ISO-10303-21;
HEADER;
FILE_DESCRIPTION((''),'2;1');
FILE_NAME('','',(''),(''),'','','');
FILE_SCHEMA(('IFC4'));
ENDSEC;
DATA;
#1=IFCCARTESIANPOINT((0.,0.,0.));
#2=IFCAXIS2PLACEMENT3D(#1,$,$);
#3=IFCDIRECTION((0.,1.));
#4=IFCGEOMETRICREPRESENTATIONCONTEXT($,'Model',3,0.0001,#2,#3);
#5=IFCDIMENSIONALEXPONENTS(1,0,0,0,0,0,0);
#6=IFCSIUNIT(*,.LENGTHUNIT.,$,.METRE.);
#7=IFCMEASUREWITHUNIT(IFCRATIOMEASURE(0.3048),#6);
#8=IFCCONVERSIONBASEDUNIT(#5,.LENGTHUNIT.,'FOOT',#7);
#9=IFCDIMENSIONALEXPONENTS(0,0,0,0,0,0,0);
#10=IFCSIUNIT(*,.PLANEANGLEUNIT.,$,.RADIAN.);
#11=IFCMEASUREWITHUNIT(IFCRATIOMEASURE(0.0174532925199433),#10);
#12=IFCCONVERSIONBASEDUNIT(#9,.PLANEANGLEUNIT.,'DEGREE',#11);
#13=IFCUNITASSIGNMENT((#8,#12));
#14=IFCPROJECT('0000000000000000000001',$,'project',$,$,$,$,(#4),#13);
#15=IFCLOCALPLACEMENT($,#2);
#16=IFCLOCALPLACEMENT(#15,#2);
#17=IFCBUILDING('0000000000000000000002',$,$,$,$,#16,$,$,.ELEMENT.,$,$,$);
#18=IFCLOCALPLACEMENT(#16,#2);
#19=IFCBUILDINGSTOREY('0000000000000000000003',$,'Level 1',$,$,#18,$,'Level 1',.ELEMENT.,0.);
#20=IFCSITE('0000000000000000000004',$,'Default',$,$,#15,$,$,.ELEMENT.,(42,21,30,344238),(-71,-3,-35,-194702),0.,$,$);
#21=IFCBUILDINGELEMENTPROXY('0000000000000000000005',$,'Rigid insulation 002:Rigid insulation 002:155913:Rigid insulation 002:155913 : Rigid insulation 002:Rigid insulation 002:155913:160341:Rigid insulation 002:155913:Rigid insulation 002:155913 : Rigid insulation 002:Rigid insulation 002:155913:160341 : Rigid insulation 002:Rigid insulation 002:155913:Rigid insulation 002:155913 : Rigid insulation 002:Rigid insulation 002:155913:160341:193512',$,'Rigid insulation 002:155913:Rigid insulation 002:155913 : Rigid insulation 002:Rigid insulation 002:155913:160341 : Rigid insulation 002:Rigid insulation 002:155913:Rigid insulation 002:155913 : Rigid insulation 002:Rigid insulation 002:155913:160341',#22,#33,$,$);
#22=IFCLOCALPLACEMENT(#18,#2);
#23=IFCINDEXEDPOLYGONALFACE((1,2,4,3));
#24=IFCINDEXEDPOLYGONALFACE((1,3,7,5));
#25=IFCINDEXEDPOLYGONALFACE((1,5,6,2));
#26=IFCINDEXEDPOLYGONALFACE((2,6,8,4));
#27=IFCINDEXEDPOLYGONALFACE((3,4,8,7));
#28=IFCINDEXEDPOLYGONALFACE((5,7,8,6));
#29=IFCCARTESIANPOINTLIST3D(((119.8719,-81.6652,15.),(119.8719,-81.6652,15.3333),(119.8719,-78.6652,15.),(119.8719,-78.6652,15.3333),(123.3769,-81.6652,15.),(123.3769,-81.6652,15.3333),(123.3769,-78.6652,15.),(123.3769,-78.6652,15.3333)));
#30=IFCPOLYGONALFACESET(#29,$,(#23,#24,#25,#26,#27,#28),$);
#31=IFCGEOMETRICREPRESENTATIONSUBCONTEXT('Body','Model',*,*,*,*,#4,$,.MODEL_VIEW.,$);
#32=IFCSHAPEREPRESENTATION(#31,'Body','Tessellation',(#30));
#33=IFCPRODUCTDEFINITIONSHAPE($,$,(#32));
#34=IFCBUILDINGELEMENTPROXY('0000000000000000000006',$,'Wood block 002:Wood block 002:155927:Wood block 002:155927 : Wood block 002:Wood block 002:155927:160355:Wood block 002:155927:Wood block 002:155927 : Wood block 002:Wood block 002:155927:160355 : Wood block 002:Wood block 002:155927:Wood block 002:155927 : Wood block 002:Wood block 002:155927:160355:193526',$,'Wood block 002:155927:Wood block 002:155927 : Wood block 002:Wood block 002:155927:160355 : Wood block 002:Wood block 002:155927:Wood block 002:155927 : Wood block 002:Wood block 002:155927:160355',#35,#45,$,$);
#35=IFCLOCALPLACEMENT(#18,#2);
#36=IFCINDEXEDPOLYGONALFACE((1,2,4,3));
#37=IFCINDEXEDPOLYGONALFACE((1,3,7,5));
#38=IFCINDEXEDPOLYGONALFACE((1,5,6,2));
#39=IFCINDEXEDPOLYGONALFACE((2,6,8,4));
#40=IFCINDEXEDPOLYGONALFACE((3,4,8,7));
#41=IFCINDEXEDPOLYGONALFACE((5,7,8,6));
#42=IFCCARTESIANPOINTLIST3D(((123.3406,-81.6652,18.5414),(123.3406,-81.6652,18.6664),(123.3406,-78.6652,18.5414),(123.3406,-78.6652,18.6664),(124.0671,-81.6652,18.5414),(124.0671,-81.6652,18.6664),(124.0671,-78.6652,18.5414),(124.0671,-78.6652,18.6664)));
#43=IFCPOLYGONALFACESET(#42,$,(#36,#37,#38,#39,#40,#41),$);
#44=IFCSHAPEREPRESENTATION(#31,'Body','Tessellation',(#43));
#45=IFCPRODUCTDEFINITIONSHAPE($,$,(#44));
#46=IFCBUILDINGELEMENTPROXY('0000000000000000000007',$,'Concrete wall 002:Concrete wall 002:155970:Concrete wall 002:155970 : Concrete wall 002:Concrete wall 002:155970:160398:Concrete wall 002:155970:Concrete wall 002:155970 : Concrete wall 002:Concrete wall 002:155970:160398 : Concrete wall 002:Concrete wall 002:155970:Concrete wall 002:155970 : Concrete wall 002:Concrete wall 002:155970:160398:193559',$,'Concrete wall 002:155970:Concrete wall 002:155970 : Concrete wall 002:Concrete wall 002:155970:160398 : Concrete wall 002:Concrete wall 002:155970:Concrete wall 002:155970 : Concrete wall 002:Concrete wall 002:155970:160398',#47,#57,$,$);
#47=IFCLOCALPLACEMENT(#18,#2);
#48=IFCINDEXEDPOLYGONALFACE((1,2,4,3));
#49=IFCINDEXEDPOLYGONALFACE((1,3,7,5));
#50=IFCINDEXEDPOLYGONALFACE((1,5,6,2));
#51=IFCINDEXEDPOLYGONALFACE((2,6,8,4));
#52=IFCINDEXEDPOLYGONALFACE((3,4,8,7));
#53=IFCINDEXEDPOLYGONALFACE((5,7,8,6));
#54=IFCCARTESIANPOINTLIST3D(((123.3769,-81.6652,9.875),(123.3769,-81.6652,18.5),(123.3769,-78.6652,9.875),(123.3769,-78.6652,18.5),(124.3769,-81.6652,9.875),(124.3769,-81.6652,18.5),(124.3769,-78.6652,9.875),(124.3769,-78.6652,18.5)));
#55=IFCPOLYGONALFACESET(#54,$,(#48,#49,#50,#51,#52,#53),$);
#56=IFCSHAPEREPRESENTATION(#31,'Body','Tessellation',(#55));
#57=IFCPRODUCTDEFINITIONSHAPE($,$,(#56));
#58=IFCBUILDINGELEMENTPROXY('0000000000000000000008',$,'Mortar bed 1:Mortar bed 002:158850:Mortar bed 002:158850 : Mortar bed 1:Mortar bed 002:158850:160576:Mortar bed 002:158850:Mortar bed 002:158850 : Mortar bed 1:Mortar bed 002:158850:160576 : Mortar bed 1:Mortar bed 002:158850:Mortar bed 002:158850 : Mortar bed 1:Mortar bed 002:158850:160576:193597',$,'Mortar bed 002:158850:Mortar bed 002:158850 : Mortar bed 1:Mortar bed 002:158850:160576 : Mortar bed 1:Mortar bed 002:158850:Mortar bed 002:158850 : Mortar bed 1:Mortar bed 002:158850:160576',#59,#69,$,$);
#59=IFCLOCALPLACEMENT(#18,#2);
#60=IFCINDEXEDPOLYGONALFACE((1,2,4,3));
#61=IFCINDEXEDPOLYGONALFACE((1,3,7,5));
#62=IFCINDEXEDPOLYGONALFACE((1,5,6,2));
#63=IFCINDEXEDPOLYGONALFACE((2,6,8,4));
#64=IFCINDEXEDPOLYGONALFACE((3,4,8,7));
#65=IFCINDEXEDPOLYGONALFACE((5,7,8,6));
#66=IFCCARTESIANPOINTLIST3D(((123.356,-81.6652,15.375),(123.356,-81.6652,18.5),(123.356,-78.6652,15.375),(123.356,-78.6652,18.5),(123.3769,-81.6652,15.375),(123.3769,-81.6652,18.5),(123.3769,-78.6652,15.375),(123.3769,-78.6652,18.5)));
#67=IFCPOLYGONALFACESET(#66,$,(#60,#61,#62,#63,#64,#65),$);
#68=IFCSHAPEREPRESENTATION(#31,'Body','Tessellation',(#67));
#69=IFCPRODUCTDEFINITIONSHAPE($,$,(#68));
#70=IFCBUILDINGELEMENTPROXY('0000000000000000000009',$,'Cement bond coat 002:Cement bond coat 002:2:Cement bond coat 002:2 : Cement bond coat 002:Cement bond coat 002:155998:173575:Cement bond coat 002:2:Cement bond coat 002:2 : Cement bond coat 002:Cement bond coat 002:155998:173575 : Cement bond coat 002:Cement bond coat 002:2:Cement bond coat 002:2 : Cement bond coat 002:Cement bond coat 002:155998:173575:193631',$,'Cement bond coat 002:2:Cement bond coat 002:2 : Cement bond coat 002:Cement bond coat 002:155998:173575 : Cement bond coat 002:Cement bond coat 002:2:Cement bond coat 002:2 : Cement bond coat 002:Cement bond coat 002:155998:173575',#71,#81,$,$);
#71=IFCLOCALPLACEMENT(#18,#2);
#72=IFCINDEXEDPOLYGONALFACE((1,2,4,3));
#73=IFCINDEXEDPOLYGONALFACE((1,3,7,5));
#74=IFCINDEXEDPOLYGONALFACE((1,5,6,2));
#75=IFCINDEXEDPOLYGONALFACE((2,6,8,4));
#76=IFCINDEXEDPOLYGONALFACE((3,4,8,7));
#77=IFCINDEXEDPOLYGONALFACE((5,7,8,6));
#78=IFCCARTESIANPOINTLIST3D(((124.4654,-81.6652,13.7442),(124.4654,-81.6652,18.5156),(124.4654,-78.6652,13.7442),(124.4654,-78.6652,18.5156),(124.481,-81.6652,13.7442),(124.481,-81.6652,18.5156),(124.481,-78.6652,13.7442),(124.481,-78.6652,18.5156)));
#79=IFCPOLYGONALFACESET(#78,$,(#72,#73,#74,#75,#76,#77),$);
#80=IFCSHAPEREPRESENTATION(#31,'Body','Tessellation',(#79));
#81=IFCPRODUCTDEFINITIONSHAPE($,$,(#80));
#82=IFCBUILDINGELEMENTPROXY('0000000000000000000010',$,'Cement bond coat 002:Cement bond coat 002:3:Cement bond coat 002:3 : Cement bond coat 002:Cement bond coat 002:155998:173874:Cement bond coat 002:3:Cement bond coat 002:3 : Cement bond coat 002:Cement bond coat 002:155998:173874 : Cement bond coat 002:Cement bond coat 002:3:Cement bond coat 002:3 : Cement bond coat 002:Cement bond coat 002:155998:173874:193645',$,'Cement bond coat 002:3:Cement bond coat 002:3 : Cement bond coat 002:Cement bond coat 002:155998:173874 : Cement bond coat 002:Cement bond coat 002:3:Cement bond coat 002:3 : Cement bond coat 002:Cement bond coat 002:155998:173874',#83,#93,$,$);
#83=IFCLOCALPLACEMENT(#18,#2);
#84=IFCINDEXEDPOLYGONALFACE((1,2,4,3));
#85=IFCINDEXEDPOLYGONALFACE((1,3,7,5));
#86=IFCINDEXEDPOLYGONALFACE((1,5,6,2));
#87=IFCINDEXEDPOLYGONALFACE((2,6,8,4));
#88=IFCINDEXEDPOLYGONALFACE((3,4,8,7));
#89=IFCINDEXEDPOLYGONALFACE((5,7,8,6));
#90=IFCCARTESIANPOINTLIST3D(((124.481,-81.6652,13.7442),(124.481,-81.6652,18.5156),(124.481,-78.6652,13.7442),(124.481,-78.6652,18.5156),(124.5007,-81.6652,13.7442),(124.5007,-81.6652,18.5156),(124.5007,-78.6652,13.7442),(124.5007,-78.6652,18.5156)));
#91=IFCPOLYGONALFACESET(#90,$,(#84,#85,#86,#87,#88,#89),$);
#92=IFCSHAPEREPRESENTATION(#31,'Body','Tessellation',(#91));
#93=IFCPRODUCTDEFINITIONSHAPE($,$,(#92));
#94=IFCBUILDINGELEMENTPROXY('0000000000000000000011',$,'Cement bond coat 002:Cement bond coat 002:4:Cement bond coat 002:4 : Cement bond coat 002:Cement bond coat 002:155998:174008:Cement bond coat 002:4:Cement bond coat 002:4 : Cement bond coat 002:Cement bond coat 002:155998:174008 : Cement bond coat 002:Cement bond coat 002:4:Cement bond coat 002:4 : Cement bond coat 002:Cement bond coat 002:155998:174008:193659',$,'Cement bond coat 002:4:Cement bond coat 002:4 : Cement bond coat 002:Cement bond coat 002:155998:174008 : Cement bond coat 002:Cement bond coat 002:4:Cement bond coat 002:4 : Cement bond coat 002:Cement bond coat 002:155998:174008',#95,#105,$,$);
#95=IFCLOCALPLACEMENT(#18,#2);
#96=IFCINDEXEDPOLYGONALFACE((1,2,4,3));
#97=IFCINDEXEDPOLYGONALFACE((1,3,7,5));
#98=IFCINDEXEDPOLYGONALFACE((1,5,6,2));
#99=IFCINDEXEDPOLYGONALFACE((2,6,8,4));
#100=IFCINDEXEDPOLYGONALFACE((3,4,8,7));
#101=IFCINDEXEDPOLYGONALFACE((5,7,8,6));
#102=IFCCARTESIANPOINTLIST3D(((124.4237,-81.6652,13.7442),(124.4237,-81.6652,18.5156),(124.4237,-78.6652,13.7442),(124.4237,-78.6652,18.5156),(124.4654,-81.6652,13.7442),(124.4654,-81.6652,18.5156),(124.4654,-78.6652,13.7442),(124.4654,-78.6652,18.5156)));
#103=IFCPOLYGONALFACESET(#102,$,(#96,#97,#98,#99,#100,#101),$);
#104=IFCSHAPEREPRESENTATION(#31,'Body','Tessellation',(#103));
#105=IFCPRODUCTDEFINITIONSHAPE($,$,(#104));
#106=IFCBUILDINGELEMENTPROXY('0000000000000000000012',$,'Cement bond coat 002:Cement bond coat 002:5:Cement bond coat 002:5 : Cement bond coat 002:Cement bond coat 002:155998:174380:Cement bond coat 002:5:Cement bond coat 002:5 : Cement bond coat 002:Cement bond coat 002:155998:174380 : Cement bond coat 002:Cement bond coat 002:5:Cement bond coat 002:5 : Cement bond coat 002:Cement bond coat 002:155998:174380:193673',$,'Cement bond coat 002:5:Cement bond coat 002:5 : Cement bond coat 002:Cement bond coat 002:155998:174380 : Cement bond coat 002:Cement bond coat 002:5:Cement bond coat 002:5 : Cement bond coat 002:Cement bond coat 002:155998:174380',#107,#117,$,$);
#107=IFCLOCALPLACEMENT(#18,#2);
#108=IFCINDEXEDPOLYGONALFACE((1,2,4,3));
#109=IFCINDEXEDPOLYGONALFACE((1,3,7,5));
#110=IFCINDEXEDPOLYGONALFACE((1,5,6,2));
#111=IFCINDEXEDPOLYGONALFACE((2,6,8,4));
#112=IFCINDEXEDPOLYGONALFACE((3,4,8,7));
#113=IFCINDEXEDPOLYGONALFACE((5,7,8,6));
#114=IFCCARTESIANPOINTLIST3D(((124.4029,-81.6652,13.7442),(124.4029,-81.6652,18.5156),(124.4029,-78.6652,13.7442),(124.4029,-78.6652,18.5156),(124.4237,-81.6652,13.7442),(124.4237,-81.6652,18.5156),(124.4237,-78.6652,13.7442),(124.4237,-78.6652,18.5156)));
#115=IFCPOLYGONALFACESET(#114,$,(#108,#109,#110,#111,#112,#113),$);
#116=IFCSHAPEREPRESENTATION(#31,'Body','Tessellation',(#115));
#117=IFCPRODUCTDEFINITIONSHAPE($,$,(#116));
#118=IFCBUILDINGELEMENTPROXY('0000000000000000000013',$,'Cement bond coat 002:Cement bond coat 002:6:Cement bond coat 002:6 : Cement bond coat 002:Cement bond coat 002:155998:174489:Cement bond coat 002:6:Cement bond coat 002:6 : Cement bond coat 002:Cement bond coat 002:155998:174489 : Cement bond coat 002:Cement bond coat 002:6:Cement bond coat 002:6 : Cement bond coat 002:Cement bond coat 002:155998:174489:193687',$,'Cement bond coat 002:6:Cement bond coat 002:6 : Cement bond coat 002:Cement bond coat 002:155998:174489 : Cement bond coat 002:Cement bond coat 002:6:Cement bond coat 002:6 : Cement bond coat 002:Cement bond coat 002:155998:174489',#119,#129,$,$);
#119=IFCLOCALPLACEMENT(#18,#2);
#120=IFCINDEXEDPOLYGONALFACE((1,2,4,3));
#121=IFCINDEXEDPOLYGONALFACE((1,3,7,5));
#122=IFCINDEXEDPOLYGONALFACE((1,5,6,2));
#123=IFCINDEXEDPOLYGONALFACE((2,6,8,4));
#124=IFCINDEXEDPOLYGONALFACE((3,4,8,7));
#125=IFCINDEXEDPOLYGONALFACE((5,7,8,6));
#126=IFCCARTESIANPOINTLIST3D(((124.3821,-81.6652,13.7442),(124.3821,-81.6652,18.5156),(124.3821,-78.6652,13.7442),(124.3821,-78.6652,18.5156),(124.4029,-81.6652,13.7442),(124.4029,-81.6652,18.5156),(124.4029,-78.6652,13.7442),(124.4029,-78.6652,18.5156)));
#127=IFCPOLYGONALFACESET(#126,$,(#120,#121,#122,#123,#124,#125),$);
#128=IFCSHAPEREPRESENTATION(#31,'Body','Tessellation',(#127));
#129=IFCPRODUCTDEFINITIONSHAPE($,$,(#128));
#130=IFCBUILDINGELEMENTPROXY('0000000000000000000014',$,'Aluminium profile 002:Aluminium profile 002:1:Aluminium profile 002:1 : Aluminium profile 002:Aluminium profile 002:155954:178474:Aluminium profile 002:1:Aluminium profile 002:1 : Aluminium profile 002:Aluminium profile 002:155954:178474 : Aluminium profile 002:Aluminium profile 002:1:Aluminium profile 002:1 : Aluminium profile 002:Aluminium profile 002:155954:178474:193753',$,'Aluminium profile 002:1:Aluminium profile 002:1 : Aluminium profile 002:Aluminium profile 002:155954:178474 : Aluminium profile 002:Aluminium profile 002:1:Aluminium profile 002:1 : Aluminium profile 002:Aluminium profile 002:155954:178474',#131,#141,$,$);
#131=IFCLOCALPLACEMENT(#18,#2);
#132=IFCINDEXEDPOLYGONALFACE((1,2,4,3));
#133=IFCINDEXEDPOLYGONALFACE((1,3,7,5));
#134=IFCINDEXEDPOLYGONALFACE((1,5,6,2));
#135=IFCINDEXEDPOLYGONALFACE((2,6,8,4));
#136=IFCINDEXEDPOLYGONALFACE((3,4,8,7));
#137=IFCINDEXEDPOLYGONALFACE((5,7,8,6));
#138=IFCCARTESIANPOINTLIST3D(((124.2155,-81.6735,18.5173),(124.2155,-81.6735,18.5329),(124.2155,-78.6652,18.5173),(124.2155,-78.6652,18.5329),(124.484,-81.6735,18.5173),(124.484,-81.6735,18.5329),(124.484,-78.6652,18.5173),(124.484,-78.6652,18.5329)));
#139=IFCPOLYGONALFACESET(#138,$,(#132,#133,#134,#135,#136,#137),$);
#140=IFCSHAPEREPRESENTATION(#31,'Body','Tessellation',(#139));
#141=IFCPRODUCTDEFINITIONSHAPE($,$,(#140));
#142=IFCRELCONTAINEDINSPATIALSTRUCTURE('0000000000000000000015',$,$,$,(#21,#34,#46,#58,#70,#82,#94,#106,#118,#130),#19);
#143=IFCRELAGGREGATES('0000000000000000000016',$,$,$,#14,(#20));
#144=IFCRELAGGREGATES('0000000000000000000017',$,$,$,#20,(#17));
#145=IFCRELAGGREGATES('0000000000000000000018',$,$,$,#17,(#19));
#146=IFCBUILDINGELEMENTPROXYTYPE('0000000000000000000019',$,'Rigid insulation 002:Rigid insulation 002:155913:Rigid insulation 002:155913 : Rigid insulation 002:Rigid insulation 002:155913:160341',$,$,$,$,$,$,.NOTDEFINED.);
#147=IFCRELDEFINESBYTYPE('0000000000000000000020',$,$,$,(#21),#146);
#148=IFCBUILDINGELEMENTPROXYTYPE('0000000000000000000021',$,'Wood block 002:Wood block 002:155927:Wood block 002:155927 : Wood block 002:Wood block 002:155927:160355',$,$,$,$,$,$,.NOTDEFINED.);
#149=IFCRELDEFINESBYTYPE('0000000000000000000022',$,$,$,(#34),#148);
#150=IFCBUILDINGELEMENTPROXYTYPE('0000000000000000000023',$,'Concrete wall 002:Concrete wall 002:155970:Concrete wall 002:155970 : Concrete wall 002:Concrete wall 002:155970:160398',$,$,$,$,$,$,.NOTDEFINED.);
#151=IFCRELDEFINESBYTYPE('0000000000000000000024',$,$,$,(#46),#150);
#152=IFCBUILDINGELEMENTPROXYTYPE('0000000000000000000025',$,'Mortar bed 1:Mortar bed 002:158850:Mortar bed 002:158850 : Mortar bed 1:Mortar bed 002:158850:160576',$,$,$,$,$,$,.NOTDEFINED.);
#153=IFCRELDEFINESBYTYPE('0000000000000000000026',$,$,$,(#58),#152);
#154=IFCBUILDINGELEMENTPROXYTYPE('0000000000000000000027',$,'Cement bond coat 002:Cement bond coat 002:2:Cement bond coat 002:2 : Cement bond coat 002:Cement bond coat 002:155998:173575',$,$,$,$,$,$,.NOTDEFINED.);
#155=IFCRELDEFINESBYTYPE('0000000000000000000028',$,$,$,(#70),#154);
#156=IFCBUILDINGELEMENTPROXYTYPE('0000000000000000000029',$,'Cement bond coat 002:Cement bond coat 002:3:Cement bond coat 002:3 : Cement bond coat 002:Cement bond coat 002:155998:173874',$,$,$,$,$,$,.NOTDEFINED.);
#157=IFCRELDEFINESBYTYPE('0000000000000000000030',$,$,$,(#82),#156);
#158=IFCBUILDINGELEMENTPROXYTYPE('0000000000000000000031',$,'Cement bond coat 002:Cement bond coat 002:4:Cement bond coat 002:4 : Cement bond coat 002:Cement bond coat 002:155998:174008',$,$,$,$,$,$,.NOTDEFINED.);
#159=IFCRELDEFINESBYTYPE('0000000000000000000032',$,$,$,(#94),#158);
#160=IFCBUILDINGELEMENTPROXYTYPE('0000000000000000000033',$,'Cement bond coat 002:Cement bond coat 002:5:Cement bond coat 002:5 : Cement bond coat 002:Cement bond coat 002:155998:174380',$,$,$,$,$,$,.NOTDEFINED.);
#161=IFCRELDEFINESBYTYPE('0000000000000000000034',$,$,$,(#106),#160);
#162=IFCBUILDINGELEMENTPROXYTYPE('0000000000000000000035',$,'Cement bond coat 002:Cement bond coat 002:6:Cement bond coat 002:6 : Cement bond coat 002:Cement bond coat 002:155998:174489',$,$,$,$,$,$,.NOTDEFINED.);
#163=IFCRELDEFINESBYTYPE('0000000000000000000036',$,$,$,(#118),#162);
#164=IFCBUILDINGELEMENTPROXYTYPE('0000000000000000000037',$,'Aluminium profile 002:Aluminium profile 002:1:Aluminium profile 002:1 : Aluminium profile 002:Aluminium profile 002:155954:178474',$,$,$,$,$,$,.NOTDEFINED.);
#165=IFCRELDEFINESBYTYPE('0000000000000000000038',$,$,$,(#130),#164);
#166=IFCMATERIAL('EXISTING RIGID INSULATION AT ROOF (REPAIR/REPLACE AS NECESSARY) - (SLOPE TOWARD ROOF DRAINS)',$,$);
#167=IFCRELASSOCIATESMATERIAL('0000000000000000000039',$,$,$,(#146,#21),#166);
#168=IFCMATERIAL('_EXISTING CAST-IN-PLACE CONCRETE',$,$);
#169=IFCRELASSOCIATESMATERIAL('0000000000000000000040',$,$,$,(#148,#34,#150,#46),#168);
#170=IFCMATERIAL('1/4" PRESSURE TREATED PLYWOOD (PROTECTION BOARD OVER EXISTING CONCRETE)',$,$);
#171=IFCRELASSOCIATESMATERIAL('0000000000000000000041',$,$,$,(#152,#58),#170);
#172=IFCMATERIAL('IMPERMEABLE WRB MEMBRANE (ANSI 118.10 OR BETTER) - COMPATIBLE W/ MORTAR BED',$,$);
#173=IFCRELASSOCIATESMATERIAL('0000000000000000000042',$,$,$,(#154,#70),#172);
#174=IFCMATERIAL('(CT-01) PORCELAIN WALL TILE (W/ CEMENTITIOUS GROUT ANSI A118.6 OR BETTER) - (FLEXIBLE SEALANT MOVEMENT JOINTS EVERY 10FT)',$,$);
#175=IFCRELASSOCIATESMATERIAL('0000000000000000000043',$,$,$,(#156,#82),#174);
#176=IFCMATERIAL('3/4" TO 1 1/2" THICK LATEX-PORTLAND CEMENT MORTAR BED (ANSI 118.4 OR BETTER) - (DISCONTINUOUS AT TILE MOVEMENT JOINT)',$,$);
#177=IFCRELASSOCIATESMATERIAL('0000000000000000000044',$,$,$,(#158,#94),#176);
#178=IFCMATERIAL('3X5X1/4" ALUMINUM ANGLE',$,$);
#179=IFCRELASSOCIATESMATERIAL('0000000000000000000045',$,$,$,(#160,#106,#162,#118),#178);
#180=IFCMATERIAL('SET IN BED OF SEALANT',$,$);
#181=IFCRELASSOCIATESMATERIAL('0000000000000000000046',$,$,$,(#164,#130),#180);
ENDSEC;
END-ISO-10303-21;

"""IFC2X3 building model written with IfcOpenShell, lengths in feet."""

from ifc_helpers import new_model, entity, si_unit, converted_unit, direction, frame, frame_2d, origin, origin_2d_with_axis, place, context, subcontext, project, spatial, rectangle, extrude, source, transform, mapped, material, type_object, type_shapes, element, save


model = new_model("IFC2X3")

# Units and contexts
model_context = context("Model", 3, precision=0.0001, world=origin(), true_north=direction((0.0, 1.0)))
body_context = subcontext(model_context, "Body", "Model", "MODEL_VIEW")
ifc_project = project(units=[converted_unit("LENGTHUNIT", "FOOT", entity("IfcRatioMeasure", 0.3048), si_unit("LENGTHUNIT", "METRE"), dimensions=[1, 0, 0, 0, 0, 0, 0]), converted_unit("PLANEANGLEUNIT", "DEGREE", entity("IfcRatioMeasure", 0.0174532925199433), si_unit("PLANEANGLEUNIT", "RADIAN"), dimensions=[0, 0, 0, 0, 0, 0, 0])], contexts=[model_context])

# Site, building, storey
site_placement = place(None, origin())
site = spatial("IfcSite", under=ifc_project, at=site_placement, Name="Default", CompositionType="ELEMENT", RefLatitude=(42, 21, 30, 344238), RefLongitude=(-71, -3, -35, -194702), RefElevation=0.0)
building_placement = place(site_placement, origin())
building = spatial("IfcBuilding", under=site, at=building_placement, CompositionType="ELEMENT")
storey_placement = place(building_placement, origin())
storey = spatial("IfcBuildingStorey", under=building, at=storey_placement, Name="Level 1", LongName="Level 1", CompositionType="ELEMENT", Elevation=0.0)

# Building element proxies
ifc_material_1 = material(Name="_EXISTING CAST-IN-PLACE CONCRETE")
ifc_material_2 = material(Name="EXISTING RIGID INSULATION AT ROOF (REPAIR/REPLACE AS NECESSARY) - (SLOPE TOWARD ROOF DRAINS)")
building_element_proxy_type_1 = type_object("IfcBuildingElementProxyType", Name="Rigid insulation 002:Rigid insulation 002:155913:Rigid insulation 002:155913 : Rigid insulation 002:Rigid insulation 002:155913:160341", PredefinedType="NOTDEFINED", material=ifc_material_2)
shared_shape_1 = source(origin(), body_context, "Body", "SweptSolid", [
    extrude(rectangle(XDim=3.0, YDim=3.505, at=frame_2d((0.0, 0.0), x_axis=(1.0, 0.0))), frame((121.6244, -80.1652, 15.0), z_axis=(0.0, 0.0, 1.0), x_axis=(0.0, -1.0, 0.0)), (0.0, 0.0, 1.0), 0.3333),
])
type_shapes(building_element_proxy_type_1, [shared_shape_1])
proxy_1_placement = place(storey_placement, origin())
element("IfcBuildingElementProxy", 1, at=proxy_1_placement, inside=storey, type_object=building_element_proxy_type_1, material=ifc_material_2, Name="Rigid insulation 002:Rigid insulation 002:155913:Rigid insulation 002:155913 : Rigid insulation 002:Rigid insulation 002:155913:160341:Rigid insulation 002:155913:Rigid insulation 002:155913 : Rigid insulation 002:Rigid insulation 002:155913:160341 : Rigid insulation 002:Rigid insulation 002:155913:Rigid insulation 002:155913 : Rigid insulation 002:Rigid insulation 002:155913:160341:193512", ObjectType="Rigid insulation 002:155913:Rigid insulation 002:155913 : Rigid insulation 002:Rigid insulation 002:155913:160341 : Rigid insulation 002:Rigid insulation 002:155913:Rigid insulation 002:155913 : Rigid insulation 002:Rigid insulation 002:155913:160341", context=body_context, shape_type="MappedRepresentation", body=[
    mapped(shared_shape_1, transform((0.0, 0.0, 0.0), scale=1.0)),
])
building_element_proxy_type_2 = type_object("IfcBuildingElementProxyType", Name="Wood block 002:Wood block 002:155927:Wood block 002:155927 : Wood block 002:Wood block 002:155927:160355", PredefinedType="NOTDEFINED", material=ifc_material_1)
shared_shape_2 = source(origin(), body_context, "Body", "SweptSolid", [
    extrude(rectangle(XDim=0.7265, YDim=3.0, at=frame_2d((0.0, 0.0), x_axis=(1.0, 0.0))), frame((123.7038, -80.1652, 18.5414)), (0.0, 0.0, 1.0), 0.125),
])
type_shapes(building_element_proxy_type_2, [shared_shape_2])
proxy_2_placement = place(storey_placement, origin())
element("IfcBuildingElementProxy", 2, at=proxy_2_placement, inside=storey, type_object=building_element_proxy_type_2, material=ifc_material_1, Name="Wood block 002:Wood block 002:155927:Wood block 002:155927 : Wood block 002:Wood block 002:155927:160355:Wood block 002:155927:Wood block 002:155927 : Wood block 002:Wood block 002:155927:160355 : Wood block 002:Wood block 002:155927:Wood block 002:155927 : Wood block 002:Wood block 002:155927:160355:193526", ObjectType="Wood block 002:155927:Wood block 002:155927 : Wood block 002:Wood block 002:155927:160355 : Wood block 002:Wood block 002:155927:Wood block 002:155927 : Wood block 002:Wood block 002:155927:160355", context=body_context, shape_type="MappedRepresentation", body=[
    mapped(shared_shape_2, transform((0.0, 0.0, 0.0), scale=1.0)),
])
ifc_material_3 = material(Name="3X5X1/4\" ALUMINUM ANGLE")
building_element_proxy_type_3 = type_object("IfcBuildingElementProxyType", Name="Concrete wall 002:Concrete wall 002:155970:Concrete wall 002:155970 : Concrete wall 002:Concrete wall 002:155970:160398", PredefinedType="NOTDEFINED", material=ifc_material_1)
shared_shape_3 = source(origin(), body_context, "Body", "SweptSolid", [
    extrude(rectangle(XDim=3.0, YDim=1.0, at=frame_2d((0.0, 0.0), x_axis=(1.0, 0.0))), frame((123.8769, -80.1652, 9.875), z_axis=(0.0, 0.0, 1.0), x_axis=(0.0, -1.0, 0.0)), (0.0, 0.0, 1.0), 8.625),
])
type_shapes(building_element_proxy_type_3, [shared_shape_3])
proxy_3_placement = place(storey_placement, origin())
element("IfcBuildingElementProxy", 3, at=proxy_3_placement, inside=storey, type_object=building_element_proxy_type_3, material=ifc_material_1, Name="Concrete wall 002:Concrete wall 002:155970:Concrete wall 002:155970 : Concrete wall 002:Concrete wall 002:155970:160398:Concrete wall 002:155970:Concrete wall 002:155970 : Concrete wall 002:Concrete wall 002:155970:160398 : Concrete wall 002:Concrete wall 002:155970:Concrete wall 002:155970 : Concrete wall 002:Concrete wall 002:155970:160398:193559", ObjectType="Concrete wall 002:155970:Concrete wall 002:155970 : Concrete wall 002:Concrete wall 002:155970:160398 : Concrete wall 002:Concrete wall 002:155970:Concrete wall 002:155970 : Concrete wall 002:Concrete wall 002:155970:160398", context=body_context, shape_type="MappedRepresentation", body=[
    mapped(shared_shape_3, transform((0.0, 0.0, 0.0), scale=1.0)),
])
ifc_material_4 = material(Name="1/4\" PRESSURE TREATED PLYWOOD (PROTECTION BOARD OVER EXISTING CONCRETE)")
building_element_proxy_type_4 = type_object("IfcBuildingElementProxyType", Name="Mortar bed 1:Mortar bed 002:158850:Mortar bed 002:158850 : Mortar bed 1:Mortar bed 002:158850:160576", PredefinedType="NOTDEFINED", material=ifc_material_4)
shared_shape_4 = source(origin(), body_context, "Body", "SweptSolid", [
    extrude(rectangle(XDim=0.0208, YDim=3.0, at=origin_2d_with_axis()), frame((123.3665, -80.1652, 15.375), z_axis=(0.0, 0.0, 1.0), x_axis=(-1.0, 0.0, 0.0)), (0.0, 0.0, 1.0), 3.125),
])
type_shapes(building_element_proxy_type_4, [shared_shape_4])
proxy_4_placement = place(storey_placement, origin())
element("IfcBuildingElementProxy", 4, at=proxy_4_placement, inside=storey, type_object=building_element_proxy_type_4, material=ifc_material_4, Name="Mortar bed 1:Mortar bed 002:158850:Mortar bed 002:158850 : Mortar bed 1:Mortar bed 002:158850:160576:Mortar bed 002:158850:Mortar bed 002:158850 : Mortar bed 1:Mortar bed 002:158850:160576 : Mortar bed 1:Mortar bed 002:158850:Mortar bed 002:158850 : Mortar bed 1:Mortar bed 002:158850:160576:193597", ObjectType="Mortar bed 002:158850:Mortar bed 002:158850 : Mortar bed 1:Mortar bed 002:158850:160576 : Mortar bed 1:Mortar bed 002:158850:Mortar bed 002:158850 : Mortar bed 1:Mortar bed 002:158850:160576", context=body_context, shape_type="MappedRepresentation", body=[
    mapped(shared_shape_4, transform((0.0, 0.0, 0.0), scale=1.0)),
])
ifc_material_5 = material(Name="IMPERMEABLE WRB MEMBRANE (ANSI 118.10 OR BETTER) - COMPATIBLE W/ MORTAR BED")
building_element_proxy_type_5 = type_object("IfcBuildingElementProxyType", Name="Cement bond coat 002:Cement bond coat 002:2:Cement bond coat 002:2 : Cement bond coat 002:Cement bond coat 002:155998:173575", PredefinedType="NOTDEFINED", material=ifc_material_5)
shared_shape_5 = source(origin(), body_context, "Body", "SweptSolid", [
    extrude(rectangle(XDim=0.0156, YDim=3.0, at=frame_2d((0.0, 0.0), x_axis=(1.0, 0.0))), frame((124.4732, -80.1652, 13.7442), z_axis=(0.0, 0.0, 1.0), x_axis=(-1.0, 0.0, 0.0)), (0.0, 0.0, 1.0), 4.7715),
])
type_shapes(building_element_proxy_type_5, [shared_shape_5])
proxy_5_placement = place(storey_placement, origin())
element("IfcBuildingElementProxy", 5, at=proxy_5_placement, inside=storey, type_object=building_element_proxy_type_5, material=ifc_material_5, Name="Cement bond coat 002:Cement bond coat 002:2:Cement bond coat 002:2 : Cement bond coat 002:Cement bond coat 002:155998:173575:Cement bond coat 002:2:Cement bond coat 002:2 : Cement bond coat 002:Cement bond coat 002:155998:173575 : Cement bond coat 002:Cement bond coat 002:2:Cement bond coat 002:2 : Cement bond coat 002:Cement bond coat 002:155998:173575:193631", ObjectType="Cement bond coat 002:2:Cement bond coat 002:2 : Cement bond coat 002:Cement bond coat 002:155998:173575 : Cement bond coat 002:Cement bond coat 002:2:Cement bond coat 002:2 : Cement bond coat 002:Cement bond coat 002:155998:173575", context=body_context, shape_type="MappedRepresentation", body=[
    mapped(shared_shape_5, transform((0.0, 0.0, 0.0), scale=1.0)),
])
ifc_material_6 = material(Name="(CT-01) PORCELAIN WALL TILE (W/ CEMENTITIOUS GROUT ANSI A118.6 OR BETTER) - (FLEXIBLE SEALANT MOVEMENT JOINTS EVERY 10FT)")
building_element_proxy_type_6 = type_object("IfcBuildingElementProxyType", Name="Cement bond coat 002:Cement bond coat 002:3:Cement bond coat 002:3 : Cement bond coat 002:Cement bond coat 002:155998:173874", PredefinedType="NOTDEFINED", material=ifc_material_6)
shared_shape_6 = source(origin(), body_context, "Body", "SweptSolid", [
    extrude(rectangle(XDim=0.0197, YDim=3.0, at=frame_2d((0.0, 0.0), x_axis=(1.0, 0.0))), frame((124.4909, -80.1652, 13.7442), z_axis=(0.0, 0.0, 1.0), x_axis=(-1.0, 0.0, 0.0)), (0.0, 0.0, 1.0), 4.7715),
])
type_shapes(building_element_proxy_type_6, [shared_shape_6])
proxy_6_placement = place(storey_placement, origin())
element("IfcBuildingElementProxy", 6, at=proxy_6_placement, inside=storey, type_object=building_element_proxy_type_6, material=ifc_material_6, Name="Cement bond coat 002:Cement bond coat 002:3:Cement bond coat 002:3 : Cement bond coat 002:Cement bond coat 002:155998:173874:Cement bond coat 002:3:Cement bond coat 002:3 : Cement bond coat 002:Cement bond coat 002:155998:173874 : Cement bond coat 002:Cement bond coat 002:3:Cement bond coat 002:3 : Cement bond coat 002:Cement bond coat 002:155998:173874:193645", ObjectType="Cement bond coat 002:3:Cement bond coat 002:3 : Cement bond coat 002:Cement bond coat 002:155998:173874 : Cement bond coat 002:Cement bond coat 002:3:Cement bond coat 002:3 : Cement bond coat 002:Cement bond coat 002:155998:173874", context=body_context, shape_type="MappedRepresentation", body=[
    mapped(shared_shape_6, transform((0.0, 0.0, 0.0), scale=1.0)),
])
ifc_material_7 = material(Name="3/4\" TO 1 1/2\" THICK LATEX-PORTLAND CEMENT MORTAR BED (ANSI 118.4 OR BETTER) - (DISCONTINUOUS AT TILE MOVEMENT JOINT)")
building_element_proxy_type_7 = type_object("IfcBuildingElementProxyType", Name="Cement bond coat 002:Cement bond coat 002:4:Cement bond coat 002:4 : Cement bond coat 002:Cement bond coat 002:155998:174008", PredefinedType="NOTDEFINED", material=ifc_material_7)
shared_shape_7 = source(origin(), body_context, "Body", "SweptSolid", [
    extrude(rectangle(XDim=0.0417, YDim=3.0, at=frame_2d((0.0, 0.0), x_axis=(1.0, 0.0))), frame((124.4446, -80.1652, 13.7442), z_axis=(0.0, 0.0, 1.0), x_axis=(-1.0, 0.0, 0.0)), (0.0, 0.0, 1.0), 4.7715),
])
type_shapes(building_element_proxy_type_7, [shared_shape_7])
proxy_7_placement = place(storey_placement, origin())
element("IfcBuildingElementProxy", 7, at=proxy_7_placement, inside=storey, type_object=building_element_proxy_type_7, material=ifc_material_7, Name="Cement bond coat 002:Cement bond coat 002:4:Cement bond coat 002:4 : Cement bond coat 002:Cement bond coat 002:155998:174008:Cement bond coat 002:4:Cement bond coat 002:4 : Cement bond coat 002:Cement bond coat 002:155998:174008 : Cement bond coat 002:Cement bond coat 002:4:Cement bond coat 002:4 : Cement bond coat 002:Cement bond coat 002:155998:174008:193659", ObjectType="Cement bond coat 002:4:Cement bond coat 002:4 : Cement bond coat 002:Cement bond coat 002:155998:174008 : Cement bond coat 002:Cement bond coat 002:4:Cement bond coat 002:4 : Cement bond coat 002:Cement bond coat 002:155998:174008", context=body_context, shape_type="MappedRepresentation", body=[
    mapped(shared_shape_7, transform((0.0, 0.0, 0.0), scale=1.0)),
])
building_element_proxy_type_8 = type_object("IfcBuildingElementProxyType", Name="Cement bond coat 002:Cement bond coat 002:5:Cement bond coat 002:5 : Cement bond coat 002:Cement bond coat 002:155998:174380", PredefinedType="NOTDEFINED", material=ifc_material_3)
shared_shape_8 = source(origin(), body_context, "Body", "SweptSolid", [
    extrude(rectangle(XDim=0.0208, YDim=3.0, at=frame_2d((0.0, 0.0), x_axis=(1.0, 0.0))), frame((124.4133, -80.1652, 13.7442), z_axis=(0.0, 0.0, 1.0), x_axis=(-1.0, 0.0, 0.0)), (0.0, 0.0, 1.0), 4.7715),
])
type_shapes(building_element_proxy_type_8, [shared_shape_8])
proxy_8_placement = place(storey_placement, origin())
element("IfcBuildingElementProxy", 8, at=proxy_8_placement, inside=storey, type_object=building_element_proxy_type_8, material=ifc_material_3, Name="Cement bond coat 002:Cement bond coat 002:5:Cement bond coat 002:5 : Cement bond coat 002:Cement bond coat 002:155998:174380:Cement bond coat 002:5:Cement bond coat 002:5 : Cement bond coat 002:Cement bond coat 002:155998:174380 : Cement bond coat 002:Cement bond coat 002:5:Cement bond coat 002:5 : Cement bond coat 002:Cement bond coat 002:155998:174380:193673", ObjectType="Cement bond coat 002:5:Cement bond coat 002:5 : Cement bond coat 002:Cement bond coat 002:155998:174380 : Cement bond coat 002:Cement bond coat 002:5:Cement bond coat 002:5 : Cement bond coat 002:Cement bond coat 002:155998:174380", context=body_context, shape_type="MappedRepresentation", body=[
    mapped(shared_shape_8, transform((0.0, 0.0, 0.0), scale=1.0)),
])
building_element_proxy_type_9 = type_object("IfcBuildingElementProxyType", Name="Cement bond coat 002:Cement bond coat 002:6:Cement bond coat 002:6 : Cement bond coat 002:Cement bond coat 002:155998:174489", PredefinedType="NOTDEFINED", material=ifc_material_3)
shared_shape_9 = source(origin(), body_context, "Body", "SweptSolid", [
    extrude(rectangle(XDim=0.0208, YDim=3.0, at=frame_2d((0.0, 0.0), x_axis=(1.0, 0.0))), frame((124.3925, -80.1652, 13.7442), z_axis=(0.0, 0.0, 1.0), x_axis=(-1.0, 0.0, 0.0)), (0.0, 0.0, 1.0), 4.7715),
])
type_shapes(building_element_proxy_type_9, [shared_shape_9])
proxy_9_placement = place(storey_placement, origin())
element("IfcBuildingElementProxy", 9, at=proxy_9_placement, inside=storey, type_object=building_element_proxy_type_9, material=ifc_material_3, Name="Cement bond coat 002:Cement bond coat 002:6:Cement bond coat 002:6 : Cement bond coat 002:Cement bond coat 002:155998:174489:Cement bond coat 002:6:Cement bond coat 002:6 : Cement bond coat 002:Cement bond coat 002:155998:174489 : Cement bond coat 002:Cement bond coat 002:6:Cement bond coat 002:6 : Cement bond coat 002:Cement bond coat 002:155998:174489:193687", ObjectType="Cement bond coat 002:6:Cement bond coat 002:6 : Cement bond coat 002:Cement bond coat 002:155998:174489 : Cement bond coat 002:Cement bond coat 002:6:Cement bond coat 002:6 : Cement bond coat 002:Cement bond coat 002:155998:174489", context=body_context, shape_type="MappedRepresentation", body=[
    mapped(shared_shape_9, transform((0.0, 0.0, 0.0), scale=1.0)),
])
ifc_material_8 = material(Name="SET IN BED OF SEALANT")
building_element_proxy_type_10 = type_object("IfcBuildingElementProxyType", Name="Aluminium profile 002:Aluminium profile 002:1:Aluminium profile 002:1 : Aluminium profile 002:Aluminium profile 002:155954:178474", PredefinedType="NOTDEFINED", material=ifc_material_8)
shared_shape_10 = source(origin(), body_context, "Body", "SweptSolid", [
    extrude(rectangle(XDim=0.2685, YDim=3.0083, at=frame_2d((0.0, 0.0), x_axis=(1.0, 0.0))), frame((124.3498, -80.1694, 18.5173), z_axis=(0.0, 0.0, 1.0), x_axis=(-1.0, 0.0, 0.0)), (0.0, 0.0, 1.0), 0.0156),
])
type_shapes(building_element_proxy_type_10, [shared_shape_10])
proxy_10_placement = place(storey_placement, origin())
element("IfcBuildingElementProxy", 10, at=proxy_10_placement, inside=storey, type_object=building_element_proxy_type_10, material=ifc_material_8, Name="Aluminium profile 002:Aluminium profile 002:1:Aluminium profile 002:1 : Aluminium profile 002:Aluminium profile 002:155954:178474:Aluminium profile 002:1:Aluminium profile 002:1 : Aluminium profile 002:Aluminium profile 002:155954:178474 : Aluminium profile 002:Aluminium profile 002:1:Aluminium profile 002:1 : Aluminium profile 002:Aluminium profile 002:155954:178474:193753", ObjectType="Aluminium profile 002:1:Aluminium profile 002:1 : Aluminium profile 002:Aluminium profile 002:155954:178474 : Aluminium profile 002:Aluminium profile 002:1:Aluminium profile 002:1 : Aluminium profile 002:Aluminium profile 002:155954:178474", context=body_context, shape_type="MappedRepresentation", body=[
    mapped(shared_shape_10, transform((0.0, 0.0, 0.0), scale=1.0)),
])

save(model, "model.ifc")
